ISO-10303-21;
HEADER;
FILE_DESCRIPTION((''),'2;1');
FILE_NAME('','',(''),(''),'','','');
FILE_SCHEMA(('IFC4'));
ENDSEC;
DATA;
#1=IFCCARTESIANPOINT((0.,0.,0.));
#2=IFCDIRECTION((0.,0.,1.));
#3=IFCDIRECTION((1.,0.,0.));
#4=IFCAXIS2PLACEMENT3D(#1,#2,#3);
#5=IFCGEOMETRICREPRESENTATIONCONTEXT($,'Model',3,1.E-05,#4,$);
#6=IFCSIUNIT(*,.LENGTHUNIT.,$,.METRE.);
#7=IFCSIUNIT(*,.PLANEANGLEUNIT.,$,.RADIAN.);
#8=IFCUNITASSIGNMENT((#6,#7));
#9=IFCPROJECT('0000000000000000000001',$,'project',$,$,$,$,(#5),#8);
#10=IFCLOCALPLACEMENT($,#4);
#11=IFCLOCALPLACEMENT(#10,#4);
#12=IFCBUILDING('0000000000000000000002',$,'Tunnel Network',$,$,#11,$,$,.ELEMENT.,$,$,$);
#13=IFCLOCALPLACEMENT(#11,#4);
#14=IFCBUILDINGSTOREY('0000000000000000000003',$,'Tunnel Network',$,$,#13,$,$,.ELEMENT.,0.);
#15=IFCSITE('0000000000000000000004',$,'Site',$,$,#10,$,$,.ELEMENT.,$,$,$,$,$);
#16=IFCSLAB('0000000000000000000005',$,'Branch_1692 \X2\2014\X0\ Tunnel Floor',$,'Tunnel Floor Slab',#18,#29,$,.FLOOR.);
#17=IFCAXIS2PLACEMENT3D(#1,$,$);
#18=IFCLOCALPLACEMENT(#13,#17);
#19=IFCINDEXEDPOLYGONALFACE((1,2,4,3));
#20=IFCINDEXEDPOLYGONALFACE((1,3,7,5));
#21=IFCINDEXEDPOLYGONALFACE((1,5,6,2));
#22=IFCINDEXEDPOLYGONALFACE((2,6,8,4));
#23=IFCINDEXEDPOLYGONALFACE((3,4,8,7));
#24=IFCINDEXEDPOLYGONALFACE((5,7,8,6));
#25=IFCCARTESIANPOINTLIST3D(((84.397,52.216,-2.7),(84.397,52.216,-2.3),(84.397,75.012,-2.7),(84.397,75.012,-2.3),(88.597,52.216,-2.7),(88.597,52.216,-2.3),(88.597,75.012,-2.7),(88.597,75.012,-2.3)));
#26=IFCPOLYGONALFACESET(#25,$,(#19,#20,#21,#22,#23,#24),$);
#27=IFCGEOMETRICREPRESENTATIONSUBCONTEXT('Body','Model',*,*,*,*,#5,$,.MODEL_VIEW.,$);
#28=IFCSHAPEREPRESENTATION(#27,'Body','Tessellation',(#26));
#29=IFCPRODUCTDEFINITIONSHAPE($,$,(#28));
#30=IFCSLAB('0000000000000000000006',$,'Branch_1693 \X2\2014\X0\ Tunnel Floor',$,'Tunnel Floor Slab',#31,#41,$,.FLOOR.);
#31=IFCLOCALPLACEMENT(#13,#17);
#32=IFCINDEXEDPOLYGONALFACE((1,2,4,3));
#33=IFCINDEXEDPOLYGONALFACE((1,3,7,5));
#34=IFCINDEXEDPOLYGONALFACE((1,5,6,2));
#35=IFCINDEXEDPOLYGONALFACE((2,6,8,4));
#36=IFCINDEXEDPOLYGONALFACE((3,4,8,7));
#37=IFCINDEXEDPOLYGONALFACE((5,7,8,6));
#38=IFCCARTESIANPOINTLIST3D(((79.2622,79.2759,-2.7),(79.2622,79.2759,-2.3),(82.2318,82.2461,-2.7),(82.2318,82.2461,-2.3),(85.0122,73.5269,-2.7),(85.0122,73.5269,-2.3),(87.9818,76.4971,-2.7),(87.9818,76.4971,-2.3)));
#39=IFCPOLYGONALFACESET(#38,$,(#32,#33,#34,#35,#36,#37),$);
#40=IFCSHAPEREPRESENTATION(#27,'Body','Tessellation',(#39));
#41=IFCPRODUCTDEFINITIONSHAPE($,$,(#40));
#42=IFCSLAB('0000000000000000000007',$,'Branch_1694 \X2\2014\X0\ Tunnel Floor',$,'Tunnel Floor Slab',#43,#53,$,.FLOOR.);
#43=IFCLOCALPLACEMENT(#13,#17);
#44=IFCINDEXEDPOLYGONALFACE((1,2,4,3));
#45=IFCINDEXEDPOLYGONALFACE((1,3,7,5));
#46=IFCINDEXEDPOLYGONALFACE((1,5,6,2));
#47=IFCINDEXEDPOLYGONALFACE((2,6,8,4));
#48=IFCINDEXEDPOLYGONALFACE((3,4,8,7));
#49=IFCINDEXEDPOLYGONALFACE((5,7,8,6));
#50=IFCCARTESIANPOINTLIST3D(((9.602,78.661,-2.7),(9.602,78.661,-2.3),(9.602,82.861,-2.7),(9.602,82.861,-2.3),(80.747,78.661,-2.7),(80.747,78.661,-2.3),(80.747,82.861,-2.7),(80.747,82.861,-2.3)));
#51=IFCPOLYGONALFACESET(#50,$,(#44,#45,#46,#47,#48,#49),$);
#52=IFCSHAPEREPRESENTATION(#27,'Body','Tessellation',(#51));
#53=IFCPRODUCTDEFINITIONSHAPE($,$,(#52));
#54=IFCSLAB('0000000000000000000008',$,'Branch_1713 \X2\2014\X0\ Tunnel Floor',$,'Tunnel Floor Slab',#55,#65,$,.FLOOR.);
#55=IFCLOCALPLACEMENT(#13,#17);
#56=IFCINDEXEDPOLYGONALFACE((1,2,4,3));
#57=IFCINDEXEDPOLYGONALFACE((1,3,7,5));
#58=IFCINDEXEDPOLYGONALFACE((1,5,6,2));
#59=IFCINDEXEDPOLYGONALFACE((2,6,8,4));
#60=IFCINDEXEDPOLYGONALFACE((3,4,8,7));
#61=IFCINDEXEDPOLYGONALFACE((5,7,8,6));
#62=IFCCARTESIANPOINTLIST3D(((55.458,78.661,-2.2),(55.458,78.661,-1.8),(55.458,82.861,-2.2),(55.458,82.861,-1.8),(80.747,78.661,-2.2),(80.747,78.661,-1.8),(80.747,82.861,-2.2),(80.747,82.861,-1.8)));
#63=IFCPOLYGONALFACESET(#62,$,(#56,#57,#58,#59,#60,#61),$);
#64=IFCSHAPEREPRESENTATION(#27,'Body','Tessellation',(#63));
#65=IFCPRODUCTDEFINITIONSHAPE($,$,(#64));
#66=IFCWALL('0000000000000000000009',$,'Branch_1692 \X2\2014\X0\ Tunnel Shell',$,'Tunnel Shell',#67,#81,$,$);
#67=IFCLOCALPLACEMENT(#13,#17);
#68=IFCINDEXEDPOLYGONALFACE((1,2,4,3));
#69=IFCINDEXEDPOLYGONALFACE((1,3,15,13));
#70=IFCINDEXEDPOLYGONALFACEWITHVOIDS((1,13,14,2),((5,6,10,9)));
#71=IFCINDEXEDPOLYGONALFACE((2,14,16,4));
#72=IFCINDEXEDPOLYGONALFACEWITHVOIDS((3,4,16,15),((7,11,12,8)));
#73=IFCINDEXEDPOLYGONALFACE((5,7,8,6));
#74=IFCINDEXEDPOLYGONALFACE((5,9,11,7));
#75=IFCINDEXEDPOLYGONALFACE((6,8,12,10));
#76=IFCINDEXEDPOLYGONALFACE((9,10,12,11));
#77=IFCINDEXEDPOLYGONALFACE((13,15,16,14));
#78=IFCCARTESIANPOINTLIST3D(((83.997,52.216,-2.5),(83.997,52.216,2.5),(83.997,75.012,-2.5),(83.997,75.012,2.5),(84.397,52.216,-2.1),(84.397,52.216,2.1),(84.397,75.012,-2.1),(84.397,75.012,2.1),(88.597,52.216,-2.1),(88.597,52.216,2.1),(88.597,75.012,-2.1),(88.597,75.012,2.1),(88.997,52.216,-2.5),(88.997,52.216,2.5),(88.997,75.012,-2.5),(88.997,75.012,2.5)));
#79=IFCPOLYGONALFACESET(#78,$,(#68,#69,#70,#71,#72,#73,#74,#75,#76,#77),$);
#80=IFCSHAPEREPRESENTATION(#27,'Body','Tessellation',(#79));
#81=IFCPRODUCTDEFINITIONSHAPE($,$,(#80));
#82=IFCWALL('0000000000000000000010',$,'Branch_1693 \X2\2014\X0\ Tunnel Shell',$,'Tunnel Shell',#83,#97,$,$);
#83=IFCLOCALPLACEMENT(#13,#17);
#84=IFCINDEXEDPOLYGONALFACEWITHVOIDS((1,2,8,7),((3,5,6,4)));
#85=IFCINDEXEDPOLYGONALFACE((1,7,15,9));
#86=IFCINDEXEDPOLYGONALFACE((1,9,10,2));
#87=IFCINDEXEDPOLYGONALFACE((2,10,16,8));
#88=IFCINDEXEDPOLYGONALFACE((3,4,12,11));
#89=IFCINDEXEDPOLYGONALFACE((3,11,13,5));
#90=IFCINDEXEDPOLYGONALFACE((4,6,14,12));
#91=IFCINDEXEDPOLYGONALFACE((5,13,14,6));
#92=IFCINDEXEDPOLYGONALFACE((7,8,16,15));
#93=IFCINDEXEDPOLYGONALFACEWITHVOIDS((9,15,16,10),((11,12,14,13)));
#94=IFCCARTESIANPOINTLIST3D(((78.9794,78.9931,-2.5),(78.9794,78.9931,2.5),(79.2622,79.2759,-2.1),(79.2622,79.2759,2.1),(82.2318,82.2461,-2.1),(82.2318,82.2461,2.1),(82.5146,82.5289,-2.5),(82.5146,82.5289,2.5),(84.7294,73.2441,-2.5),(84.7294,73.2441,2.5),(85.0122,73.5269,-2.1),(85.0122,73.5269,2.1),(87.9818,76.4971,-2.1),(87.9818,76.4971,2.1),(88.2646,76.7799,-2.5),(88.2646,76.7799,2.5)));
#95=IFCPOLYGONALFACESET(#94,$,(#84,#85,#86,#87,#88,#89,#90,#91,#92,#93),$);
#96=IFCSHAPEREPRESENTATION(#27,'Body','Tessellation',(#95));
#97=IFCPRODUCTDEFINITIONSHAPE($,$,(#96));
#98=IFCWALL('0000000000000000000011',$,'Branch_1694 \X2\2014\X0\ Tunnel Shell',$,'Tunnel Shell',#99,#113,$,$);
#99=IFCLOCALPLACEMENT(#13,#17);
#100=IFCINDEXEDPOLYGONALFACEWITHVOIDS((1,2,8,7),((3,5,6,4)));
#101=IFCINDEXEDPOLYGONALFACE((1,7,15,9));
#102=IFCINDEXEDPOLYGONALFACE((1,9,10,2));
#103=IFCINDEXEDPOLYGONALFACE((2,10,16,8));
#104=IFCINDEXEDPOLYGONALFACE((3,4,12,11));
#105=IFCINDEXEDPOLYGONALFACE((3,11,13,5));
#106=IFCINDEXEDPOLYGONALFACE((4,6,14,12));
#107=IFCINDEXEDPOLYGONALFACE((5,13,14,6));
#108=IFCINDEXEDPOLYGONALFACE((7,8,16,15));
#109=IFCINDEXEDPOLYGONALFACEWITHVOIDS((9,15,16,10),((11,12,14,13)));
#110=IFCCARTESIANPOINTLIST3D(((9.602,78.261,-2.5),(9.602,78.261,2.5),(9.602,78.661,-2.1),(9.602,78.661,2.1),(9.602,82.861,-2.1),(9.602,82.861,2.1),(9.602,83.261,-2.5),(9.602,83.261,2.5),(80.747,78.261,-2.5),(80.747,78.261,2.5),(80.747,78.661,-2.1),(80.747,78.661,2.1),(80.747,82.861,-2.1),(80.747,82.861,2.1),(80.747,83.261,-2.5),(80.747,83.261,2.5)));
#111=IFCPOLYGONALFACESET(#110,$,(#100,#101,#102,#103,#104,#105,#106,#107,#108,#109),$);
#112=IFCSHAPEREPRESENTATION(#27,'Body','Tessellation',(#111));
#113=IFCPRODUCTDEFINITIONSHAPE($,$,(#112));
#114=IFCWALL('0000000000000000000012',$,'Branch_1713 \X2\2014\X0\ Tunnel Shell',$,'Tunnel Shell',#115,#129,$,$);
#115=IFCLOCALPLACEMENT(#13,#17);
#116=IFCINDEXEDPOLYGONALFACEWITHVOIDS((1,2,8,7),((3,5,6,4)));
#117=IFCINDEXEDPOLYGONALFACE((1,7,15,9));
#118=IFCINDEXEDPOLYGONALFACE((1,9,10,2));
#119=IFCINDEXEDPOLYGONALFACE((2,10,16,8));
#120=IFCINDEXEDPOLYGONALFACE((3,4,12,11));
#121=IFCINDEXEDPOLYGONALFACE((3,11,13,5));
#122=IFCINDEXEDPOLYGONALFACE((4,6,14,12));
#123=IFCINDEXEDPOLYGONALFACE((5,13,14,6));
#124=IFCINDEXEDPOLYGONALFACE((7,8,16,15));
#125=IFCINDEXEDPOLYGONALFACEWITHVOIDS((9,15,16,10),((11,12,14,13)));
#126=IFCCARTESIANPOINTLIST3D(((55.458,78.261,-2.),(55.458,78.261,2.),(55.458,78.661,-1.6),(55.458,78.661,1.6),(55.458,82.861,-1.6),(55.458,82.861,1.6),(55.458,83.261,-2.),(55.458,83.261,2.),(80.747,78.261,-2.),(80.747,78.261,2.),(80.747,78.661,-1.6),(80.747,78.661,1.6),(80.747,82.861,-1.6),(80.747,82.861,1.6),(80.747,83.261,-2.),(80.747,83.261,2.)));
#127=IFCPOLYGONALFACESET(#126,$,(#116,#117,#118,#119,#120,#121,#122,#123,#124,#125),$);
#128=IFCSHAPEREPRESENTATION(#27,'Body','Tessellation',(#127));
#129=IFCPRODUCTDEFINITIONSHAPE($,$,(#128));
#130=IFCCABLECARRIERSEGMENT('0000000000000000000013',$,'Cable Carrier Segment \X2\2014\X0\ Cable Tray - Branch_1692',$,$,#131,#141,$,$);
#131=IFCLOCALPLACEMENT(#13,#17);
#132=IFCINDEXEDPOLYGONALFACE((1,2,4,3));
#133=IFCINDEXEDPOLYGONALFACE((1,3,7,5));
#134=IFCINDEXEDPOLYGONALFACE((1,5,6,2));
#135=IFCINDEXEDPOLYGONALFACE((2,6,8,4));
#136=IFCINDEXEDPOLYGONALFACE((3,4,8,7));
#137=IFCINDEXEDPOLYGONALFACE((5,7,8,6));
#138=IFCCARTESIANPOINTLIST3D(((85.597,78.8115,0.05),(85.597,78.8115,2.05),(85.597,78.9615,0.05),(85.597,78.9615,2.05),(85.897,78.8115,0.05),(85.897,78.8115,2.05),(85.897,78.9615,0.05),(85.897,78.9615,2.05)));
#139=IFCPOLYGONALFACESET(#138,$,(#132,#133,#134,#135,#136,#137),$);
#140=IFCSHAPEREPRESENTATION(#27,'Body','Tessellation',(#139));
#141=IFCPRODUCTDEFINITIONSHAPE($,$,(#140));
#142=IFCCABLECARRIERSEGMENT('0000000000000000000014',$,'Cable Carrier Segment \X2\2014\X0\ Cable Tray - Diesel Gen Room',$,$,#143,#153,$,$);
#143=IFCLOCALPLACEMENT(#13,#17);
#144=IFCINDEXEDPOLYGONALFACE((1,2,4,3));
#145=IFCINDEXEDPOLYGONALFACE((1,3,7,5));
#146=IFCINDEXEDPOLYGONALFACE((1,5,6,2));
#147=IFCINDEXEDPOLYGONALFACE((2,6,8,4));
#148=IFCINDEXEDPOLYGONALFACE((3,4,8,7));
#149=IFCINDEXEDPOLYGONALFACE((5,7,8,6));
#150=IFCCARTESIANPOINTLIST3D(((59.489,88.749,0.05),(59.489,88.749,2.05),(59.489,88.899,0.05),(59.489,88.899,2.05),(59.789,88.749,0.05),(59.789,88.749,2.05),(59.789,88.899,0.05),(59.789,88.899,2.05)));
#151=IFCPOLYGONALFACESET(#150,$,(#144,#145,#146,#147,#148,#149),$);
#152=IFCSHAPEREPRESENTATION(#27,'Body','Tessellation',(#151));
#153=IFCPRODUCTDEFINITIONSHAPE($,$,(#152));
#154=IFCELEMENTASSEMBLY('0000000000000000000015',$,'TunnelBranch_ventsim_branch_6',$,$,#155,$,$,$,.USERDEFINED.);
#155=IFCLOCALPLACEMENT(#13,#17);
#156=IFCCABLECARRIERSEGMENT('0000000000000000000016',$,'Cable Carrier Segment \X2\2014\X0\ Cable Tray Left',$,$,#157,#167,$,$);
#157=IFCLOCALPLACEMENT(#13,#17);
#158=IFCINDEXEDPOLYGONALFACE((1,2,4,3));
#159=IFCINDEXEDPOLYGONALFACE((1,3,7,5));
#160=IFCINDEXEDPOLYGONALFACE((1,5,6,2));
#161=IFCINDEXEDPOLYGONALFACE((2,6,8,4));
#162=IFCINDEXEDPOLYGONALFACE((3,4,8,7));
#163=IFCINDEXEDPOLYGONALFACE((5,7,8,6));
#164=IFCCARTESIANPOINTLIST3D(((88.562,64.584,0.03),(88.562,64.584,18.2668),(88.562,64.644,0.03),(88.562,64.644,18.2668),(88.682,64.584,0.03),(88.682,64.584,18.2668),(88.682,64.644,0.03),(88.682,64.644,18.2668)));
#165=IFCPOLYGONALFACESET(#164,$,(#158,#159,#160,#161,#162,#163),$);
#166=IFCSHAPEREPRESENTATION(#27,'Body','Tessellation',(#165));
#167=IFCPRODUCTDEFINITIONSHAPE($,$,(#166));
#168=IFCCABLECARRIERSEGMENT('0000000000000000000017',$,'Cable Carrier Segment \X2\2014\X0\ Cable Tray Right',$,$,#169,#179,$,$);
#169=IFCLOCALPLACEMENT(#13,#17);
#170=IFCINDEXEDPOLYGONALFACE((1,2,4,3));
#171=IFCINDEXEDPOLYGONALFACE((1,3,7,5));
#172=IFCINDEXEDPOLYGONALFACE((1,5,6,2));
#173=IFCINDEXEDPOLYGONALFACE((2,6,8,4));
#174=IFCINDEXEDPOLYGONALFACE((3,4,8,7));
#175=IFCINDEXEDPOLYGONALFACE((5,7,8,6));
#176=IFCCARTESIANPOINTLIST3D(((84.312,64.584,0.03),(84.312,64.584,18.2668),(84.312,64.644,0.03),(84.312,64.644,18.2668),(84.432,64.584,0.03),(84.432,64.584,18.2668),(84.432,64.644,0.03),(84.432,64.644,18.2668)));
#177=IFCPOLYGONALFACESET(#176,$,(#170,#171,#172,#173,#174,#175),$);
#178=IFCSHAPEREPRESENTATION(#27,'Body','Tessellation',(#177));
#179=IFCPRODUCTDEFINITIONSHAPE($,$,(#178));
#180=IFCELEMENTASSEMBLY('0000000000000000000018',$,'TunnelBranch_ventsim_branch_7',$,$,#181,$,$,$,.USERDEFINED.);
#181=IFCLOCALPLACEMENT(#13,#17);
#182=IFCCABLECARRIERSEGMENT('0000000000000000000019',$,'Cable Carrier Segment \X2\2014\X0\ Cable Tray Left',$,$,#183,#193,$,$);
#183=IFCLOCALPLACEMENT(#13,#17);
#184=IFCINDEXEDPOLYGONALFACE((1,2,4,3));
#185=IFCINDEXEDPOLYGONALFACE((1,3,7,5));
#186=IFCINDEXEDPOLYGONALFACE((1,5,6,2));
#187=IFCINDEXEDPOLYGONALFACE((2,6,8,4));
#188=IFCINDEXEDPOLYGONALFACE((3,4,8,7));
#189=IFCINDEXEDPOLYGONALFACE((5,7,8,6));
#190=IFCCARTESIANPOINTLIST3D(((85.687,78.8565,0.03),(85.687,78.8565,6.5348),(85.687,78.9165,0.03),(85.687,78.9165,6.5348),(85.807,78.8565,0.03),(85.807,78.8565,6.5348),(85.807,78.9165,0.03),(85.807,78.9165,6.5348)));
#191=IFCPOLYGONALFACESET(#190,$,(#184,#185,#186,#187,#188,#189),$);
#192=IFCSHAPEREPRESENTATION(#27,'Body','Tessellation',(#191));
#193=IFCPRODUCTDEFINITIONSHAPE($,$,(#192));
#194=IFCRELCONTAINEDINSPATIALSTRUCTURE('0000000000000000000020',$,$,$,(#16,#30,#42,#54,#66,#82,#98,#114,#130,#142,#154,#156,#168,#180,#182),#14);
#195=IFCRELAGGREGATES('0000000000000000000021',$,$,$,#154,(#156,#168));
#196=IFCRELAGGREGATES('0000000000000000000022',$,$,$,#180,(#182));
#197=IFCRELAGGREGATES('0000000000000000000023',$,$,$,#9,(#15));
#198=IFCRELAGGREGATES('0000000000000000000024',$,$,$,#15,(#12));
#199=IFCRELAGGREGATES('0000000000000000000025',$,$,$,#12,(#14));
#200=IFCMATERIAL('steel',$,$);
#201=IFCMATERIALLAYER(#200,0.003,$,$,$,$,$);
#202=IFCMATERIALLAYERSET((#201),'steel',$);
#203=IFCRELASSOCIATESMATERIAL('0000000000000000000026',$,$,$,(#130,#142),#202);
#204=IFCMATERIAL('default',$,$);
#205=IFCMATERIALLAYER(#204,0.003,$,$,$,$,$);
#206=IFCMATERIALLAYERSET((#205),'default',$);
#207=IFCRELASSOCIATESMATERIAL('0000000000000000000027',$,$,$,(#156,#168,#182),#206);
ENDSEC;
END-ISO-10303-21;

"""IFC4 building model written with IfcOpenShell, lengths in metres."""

from ifc_helpers import new_model, si_unit, frame, origin_with_axes, origin_2d_with_axis, place, context, subcontext, project, spatial, rectangle, hollow_rectangle, extrude, material, layer, layer_set, layer_usage, element, aggregate, save


model = new_model("IFC4")

# Units and contexts
model_context = context("Model", 3, precision=1e-05, world=origin_with_axes())
body_context = subcontext(model_context, "Body", "Model", "MODEL_VIEW")
ifc_project = project(units=[si_unit("LENGTHUNIT", "METRE"), si_unit("PLANEANGLEUNIT", "RADIAN")], contexts=[model_context])

# Site, building, storey
site_placement = place(None, origin_with_axes())
site = spatial("IfcSite", under=ifc_project, at=site_placement, Name="Site", CompositionType="ELEMENT")
building_placement = place(site_placement, origin_with_axes())
building = spatial("IfcBuilding", under=site, at=building_placement, Name="Tunnel Network", CompositionType="ELEMENT")
storey_placement = place(building_placement, origin_with_axes())
storey = spatial("IfcBuildingStorey", under=building, at=storey_placement, Name="Tunnel Network", CompositionType="ELEMENT", Elevation=0.0)

# Slabs
placement_1 = place(storey_placement, frame((86.497, 75.012, 0.0), z_axis=(0.0, 0.0, 1.0), x_axis=(0.0, -1.0, 0.0)))
element("IfcSlab", 1, at=placement_1, inside=storey, Name="Branch_1692 — Tunnel Floor", ObjectType="Tunnel Floor Slab", PredefinedType="FLOOR", context=body_context, shape_type="SweptSolid", body=[
    extrude(rectangle(XDim=0.4, YDim=4.2, at=origin_2d_with_axis()), frame((0.0, 0.0, -2.5), z_axis=(1.0, 0.0, 0.0), x_axis=(0.0, 0.0, 1.0)), (0.0, 0.0, 1.0), 22.796),
])
placement_2 = place(storey_placement, frame((80.747, 80.761, 0.0), z_axis=(0.0, 0.0, 1.0), x_axis=(0.707168, -0.707045, 0.0)))
element("IfcSlab", 2, at=placement_2, inside=storey, Name="Branch_1693 — Tunnel Floor", ObjectType="Tunnel Floor Slab", PredefinedType="FLOOR", context=body_context, shape_type="SweptSolid", body=[
    extrude(rectangle(XDim=0.4, YDim=4.2, at=origin_2d_with_axis()), frame((0.0, 0.0, -2.5), z_axis=(1.0, 0.0, 0.0), x_axis=(0.0, 0.0, 1.0)), (0.0, 0.0, 1.0), 8.131),
])
placement_3 = place(storey_placement, frame((80.747, 80.761, 0.0), z_axis=(0.0, 0.0, 1.0), x_axis=(-1.0, 0.0, 0.0)))
element("IfcSlab", 3, at=placement_3, inside=storey, Name="Branch_1694 — Tunnel Floor", ObjectType="Tunnel Floor Slab", PredefinedType="FLOOR", context=body_context, shape_type="SweptSolid", body=[
    extrude(rectangle(XDim=0.4, YDim=4.2, at=origin_2d_with_axis()), frame((0.0, 0.0, -2.5), z_axis=(1.0, 0.0, 0.0), x_axis=(0.0, 0.0, 1.0)), (0.0, 0.0, 1.0), 71.145),
])
placement_4 = place(storey_placement, frame((80.747, 80.761, 0.0), z_axis=(0.0, 0.0, 1.0), x_axis=(-1.0, 0.0, 0.0)))
element("IfcSlab", 4, at=placement_4, inside=storey, Name="Branch_1713 — Tunnel Floor", ObjectType="Tunnel Floor Slab", PredefinedType="FLOOR", context=body_context, shape_type="SweptSolid", body=[
    extrude(rectangle(XDim=0.4, YDim=4.2, at=origin_2d_with_axis()), frame((0.0, 0.0, -2.0), z_axis=(1.0, 0.0, 0.0), x_axis=(0.0, 0.0, 1.0)), (0.0, 0.0, 1.0), 25.289),
])

# Walls
element("IfcWall", 5, at=placement_1, inside=storey, Name="Branch_1692 — Tunnel Shell", ObjectType="Tunnel Shell", context=body_context, shape_type="SweptSolid", body=[
    extrude(hollow_rectangle(XDim=5.0, YDim=5.0, WallThickness=0.4, at=origin_2d_with_axis()), frame((0.0, 0.0, 0.0), z_axis=(1.0, 0.0, 0.0), x_axis=(0.0, 0.0, 1.0)), (0.0, 0.0, 1.0), 22.796),
])
element("IfcWall", 6, at=placement_2, inside=storey, Name="Branch_1693 — Tunnel Shell", ObjectType="Tunnel Shell", context=body_context, shape_type="SweptSolid", body=[
    extrude(hollow_rectangle(XDim=5.0, YDim=5.0, WallThickness=0.4, at=origin_2d_with_axis()), frame((0.0, 0.0, 0.0), z_axis=(1.0, 0.0, 0.0), x_axis=(0.0, 0.0, 1.0)), (0.0, 0.0, 1.0), 8.131),
])
element("IfcWall", 7, at=placement_3, inside=storey, Name="Branch_1694 — Tunnel Shell", ObjectType="Tunnel Shell", context=body_context, shape_type="SweptSolid", body=[
    extrude(hollow_rectangle(XDim=5.0, YDim=5.0, WallThickness=0.4, at=origin_2d_with_axis()), frame((0.0, 0.0, 0.0), z_axis=(1.0, 0.0, 0.0), x_axis=(0.0, 0.0, 1.0)), (0.0, 0.0, 1.0), 71.145),
])
element("IfcWall", 8, at=placement_4, inside=storey, Name="Branch_1713 — Tunnel Shell", ObjectType="Tunnel Shell", context=body_context, shape_type="SweptSolid", body=[
    extrude(hollow_rectangle(XDim=4.0, YDim=5.0, WallThickness=0.4, at=origin_2d_with_axis()), frame((0.0, 0.0, 0.0), z_axis=(1.0, 0.0, 0.0), x_axis=(0.0, 0.0, 1.0)), (0.0, 0.0, 1.0), 25.289),
])

# Cable carrier segments
ifc_material_1 = material(Name="steel")
ifc_layer_1 = layer(ifc_material_1, 0.003)
ifc_layer_set_1 = layer_set([ifc_layer_1], Name="steel")
ifc_layer_usage_1 = layer_usage(ifc_layer_set_1, "AXIS2", "POSITIVE", 0.0)
cable_carrier_segment_1_placement = place(storey_placement, frame((85.747, 78.8865, 0.05), z_axis=(0.0, 0.0, 1.0), x_axis=(-1.0, 0.0, 0.0)))
element("IfcCableCarrierSegment", 9, at=cable_carrier_segment_1_placement, inside=storey, material=ifc_layer_usage_1, Name="Cable Carrier Segment — Cable Tray - Branch_1692", context=body_context, shape_type="SweptSolid", body=[
    extrude(rectangle(XDim=0.3, YDim=0.15, at=origin_2d_with_axis()), origin_with_axes(), (0.0, 0.0, 1.0), 2.0),
])
ifc_layer_usage_2 = layer_usage(ifc_layer_set_1, "AXIS2", "POSITIVE", 0.0)
cable_carrier_segment_2_placement = place(storey_placement, frame((59.639, 88.824, 0.05), z_axis=(0.0, 0.0, 1.0), x_axis=(-1.0, 0.0, 0.0)))
element("IfcCableCarrierSegment", 10, at=cable_carrier_segment_2_placement, inside=storey, material=ifc_layer_usage_2, Name="Cable Carrier Segment — Cable Tray - Diesel Gen Room", context=body_context, shape_type="SweptSolid", body=[
    extrude(rectangle(XDim=0.3, YDim=0.15, at=origin_2d_with_axis()), origin_with_axes(), (0.0, 0.0, 1.0), 2.0),
])

# Element assemblies, cable carrier segments
assembly_1_placement = place(storey_placement, frame((86.497, 65.739, 1.25), z_axis=(0.0, 1.0, 0.0), x_axis=(-1.0, 0.0, 0.0)))
assembly_1 = element("IfcElementAssembly", 11, at=assembly_1_placement, inside=storey, Name="TunnelBranch_ventsim_branch_6", PredefinedType="USERDEFINED")
ifc_material_2 = material(Name="default")
ifc_layer_2 = layer(ifc_material_2, 0.003)
ifc_layer_set_2 = layer_set([ifc_layer_2], Name="default")
ifc_layer_usage_3 = layer_usage(ifc_layer_set_2, "AXIS2", "POSITIVE", 0.0)
cable_carrier_segment_3_placement = place(storey_placement, frame((88.622, 64.614, 0.03), z_axis=(0.0, 0.0, 1.0), x_axis=(-1.0, 0.0, 0.0)))
cable_carrier_segment_3 = element("IfcCableCarrierSegment", 12, at=cable_carrier_segment_3_placement, inside=storey, material=ifc_layer_usage_3, Name="Cable Carrier Segment — Cable Tray Left", context=body_context, shape_type="SweptSolid", body=[
    extrude(rectangle(XDim=0.12, YDim=0.06, at=origin_2d_with_axis()), origin_with_axes(), (0.0, 0.0, 1.0), 18.2368),
])
ifc_layer_usage_4 = layer_usage(ifc_layer_set_2, "AXIS2", "POSITIVE", 0.0)
cable_carrier_segment_4_placement = place(storey_placement, frame((84.372, 64.614, 0.03), z_axis=(0.0, 0.0, 1.0), x_axis=(-1.0, 0.0, 0.0)))
cable_carrier_segment_4 = element("IfcCableCarrierSegment", 13, at=cable_carrier_segment_4_placement, inside=storey, material=ifc_layer_usage_4, Name="Cable Carrier Segment — Cable Tray Right", context=body_context, shape_type="SweptSolid", body=[
    extrude(rectangle(XDim=0.12, YDim=0.06, at=origin_2d_with_axis()), origin_with_axes(), (0.0, 0.0, 1.0), 18.2368),
])
aggregate(assembly_1, [cable_carrier_segment_3, cable_carrier_segment_4])
assembly_2_placement = place(storey_placement, frame((83.622, 80.0115, 0.8131), z_axis=(0.0, 0.0, 1.0), x_axis=(-1.0, 0.0, 0.0)))
assembly_2 = element("IfcElementAssembly", 14, at=assembly_2_placement, inside=storey, Name="TunnelBranch_ventsim_branch_7", PredefinedType="USERDEFINED")
ifc_layer_usage_5 = layer_usage(ifc_layer_set_2, "AXIS2", "POSITIVE", 0.0)
cable_carrier_segment_5_placement = place(storey_placement, frame((85.747, 78.8865, 0.03), z_axis=(0.0, 0.0, 1.0), x_axis=(-1.0, 0.0, 0.0)))
cable_carrier_segment_5 = element("IfcCableCarrierSegment", 15, at=cable_carrier_segment_5_placement, inside=storey, material=ifc_layer_usage_5, Name="Cable Carrier Segment — Cable Tray Left", context=body_context, shape_type="SweptSolid", body=[
    extrude(rectangle(XDim=0.12, YDim=0.06, at=origin_2d_with_axis()), origin_with_axes(), (0.0, 0.0, 1.0), 6.5048),
])
aggregate(assembly_2, [cable_carrier_segment_5])

save(model, "model.ifc")
